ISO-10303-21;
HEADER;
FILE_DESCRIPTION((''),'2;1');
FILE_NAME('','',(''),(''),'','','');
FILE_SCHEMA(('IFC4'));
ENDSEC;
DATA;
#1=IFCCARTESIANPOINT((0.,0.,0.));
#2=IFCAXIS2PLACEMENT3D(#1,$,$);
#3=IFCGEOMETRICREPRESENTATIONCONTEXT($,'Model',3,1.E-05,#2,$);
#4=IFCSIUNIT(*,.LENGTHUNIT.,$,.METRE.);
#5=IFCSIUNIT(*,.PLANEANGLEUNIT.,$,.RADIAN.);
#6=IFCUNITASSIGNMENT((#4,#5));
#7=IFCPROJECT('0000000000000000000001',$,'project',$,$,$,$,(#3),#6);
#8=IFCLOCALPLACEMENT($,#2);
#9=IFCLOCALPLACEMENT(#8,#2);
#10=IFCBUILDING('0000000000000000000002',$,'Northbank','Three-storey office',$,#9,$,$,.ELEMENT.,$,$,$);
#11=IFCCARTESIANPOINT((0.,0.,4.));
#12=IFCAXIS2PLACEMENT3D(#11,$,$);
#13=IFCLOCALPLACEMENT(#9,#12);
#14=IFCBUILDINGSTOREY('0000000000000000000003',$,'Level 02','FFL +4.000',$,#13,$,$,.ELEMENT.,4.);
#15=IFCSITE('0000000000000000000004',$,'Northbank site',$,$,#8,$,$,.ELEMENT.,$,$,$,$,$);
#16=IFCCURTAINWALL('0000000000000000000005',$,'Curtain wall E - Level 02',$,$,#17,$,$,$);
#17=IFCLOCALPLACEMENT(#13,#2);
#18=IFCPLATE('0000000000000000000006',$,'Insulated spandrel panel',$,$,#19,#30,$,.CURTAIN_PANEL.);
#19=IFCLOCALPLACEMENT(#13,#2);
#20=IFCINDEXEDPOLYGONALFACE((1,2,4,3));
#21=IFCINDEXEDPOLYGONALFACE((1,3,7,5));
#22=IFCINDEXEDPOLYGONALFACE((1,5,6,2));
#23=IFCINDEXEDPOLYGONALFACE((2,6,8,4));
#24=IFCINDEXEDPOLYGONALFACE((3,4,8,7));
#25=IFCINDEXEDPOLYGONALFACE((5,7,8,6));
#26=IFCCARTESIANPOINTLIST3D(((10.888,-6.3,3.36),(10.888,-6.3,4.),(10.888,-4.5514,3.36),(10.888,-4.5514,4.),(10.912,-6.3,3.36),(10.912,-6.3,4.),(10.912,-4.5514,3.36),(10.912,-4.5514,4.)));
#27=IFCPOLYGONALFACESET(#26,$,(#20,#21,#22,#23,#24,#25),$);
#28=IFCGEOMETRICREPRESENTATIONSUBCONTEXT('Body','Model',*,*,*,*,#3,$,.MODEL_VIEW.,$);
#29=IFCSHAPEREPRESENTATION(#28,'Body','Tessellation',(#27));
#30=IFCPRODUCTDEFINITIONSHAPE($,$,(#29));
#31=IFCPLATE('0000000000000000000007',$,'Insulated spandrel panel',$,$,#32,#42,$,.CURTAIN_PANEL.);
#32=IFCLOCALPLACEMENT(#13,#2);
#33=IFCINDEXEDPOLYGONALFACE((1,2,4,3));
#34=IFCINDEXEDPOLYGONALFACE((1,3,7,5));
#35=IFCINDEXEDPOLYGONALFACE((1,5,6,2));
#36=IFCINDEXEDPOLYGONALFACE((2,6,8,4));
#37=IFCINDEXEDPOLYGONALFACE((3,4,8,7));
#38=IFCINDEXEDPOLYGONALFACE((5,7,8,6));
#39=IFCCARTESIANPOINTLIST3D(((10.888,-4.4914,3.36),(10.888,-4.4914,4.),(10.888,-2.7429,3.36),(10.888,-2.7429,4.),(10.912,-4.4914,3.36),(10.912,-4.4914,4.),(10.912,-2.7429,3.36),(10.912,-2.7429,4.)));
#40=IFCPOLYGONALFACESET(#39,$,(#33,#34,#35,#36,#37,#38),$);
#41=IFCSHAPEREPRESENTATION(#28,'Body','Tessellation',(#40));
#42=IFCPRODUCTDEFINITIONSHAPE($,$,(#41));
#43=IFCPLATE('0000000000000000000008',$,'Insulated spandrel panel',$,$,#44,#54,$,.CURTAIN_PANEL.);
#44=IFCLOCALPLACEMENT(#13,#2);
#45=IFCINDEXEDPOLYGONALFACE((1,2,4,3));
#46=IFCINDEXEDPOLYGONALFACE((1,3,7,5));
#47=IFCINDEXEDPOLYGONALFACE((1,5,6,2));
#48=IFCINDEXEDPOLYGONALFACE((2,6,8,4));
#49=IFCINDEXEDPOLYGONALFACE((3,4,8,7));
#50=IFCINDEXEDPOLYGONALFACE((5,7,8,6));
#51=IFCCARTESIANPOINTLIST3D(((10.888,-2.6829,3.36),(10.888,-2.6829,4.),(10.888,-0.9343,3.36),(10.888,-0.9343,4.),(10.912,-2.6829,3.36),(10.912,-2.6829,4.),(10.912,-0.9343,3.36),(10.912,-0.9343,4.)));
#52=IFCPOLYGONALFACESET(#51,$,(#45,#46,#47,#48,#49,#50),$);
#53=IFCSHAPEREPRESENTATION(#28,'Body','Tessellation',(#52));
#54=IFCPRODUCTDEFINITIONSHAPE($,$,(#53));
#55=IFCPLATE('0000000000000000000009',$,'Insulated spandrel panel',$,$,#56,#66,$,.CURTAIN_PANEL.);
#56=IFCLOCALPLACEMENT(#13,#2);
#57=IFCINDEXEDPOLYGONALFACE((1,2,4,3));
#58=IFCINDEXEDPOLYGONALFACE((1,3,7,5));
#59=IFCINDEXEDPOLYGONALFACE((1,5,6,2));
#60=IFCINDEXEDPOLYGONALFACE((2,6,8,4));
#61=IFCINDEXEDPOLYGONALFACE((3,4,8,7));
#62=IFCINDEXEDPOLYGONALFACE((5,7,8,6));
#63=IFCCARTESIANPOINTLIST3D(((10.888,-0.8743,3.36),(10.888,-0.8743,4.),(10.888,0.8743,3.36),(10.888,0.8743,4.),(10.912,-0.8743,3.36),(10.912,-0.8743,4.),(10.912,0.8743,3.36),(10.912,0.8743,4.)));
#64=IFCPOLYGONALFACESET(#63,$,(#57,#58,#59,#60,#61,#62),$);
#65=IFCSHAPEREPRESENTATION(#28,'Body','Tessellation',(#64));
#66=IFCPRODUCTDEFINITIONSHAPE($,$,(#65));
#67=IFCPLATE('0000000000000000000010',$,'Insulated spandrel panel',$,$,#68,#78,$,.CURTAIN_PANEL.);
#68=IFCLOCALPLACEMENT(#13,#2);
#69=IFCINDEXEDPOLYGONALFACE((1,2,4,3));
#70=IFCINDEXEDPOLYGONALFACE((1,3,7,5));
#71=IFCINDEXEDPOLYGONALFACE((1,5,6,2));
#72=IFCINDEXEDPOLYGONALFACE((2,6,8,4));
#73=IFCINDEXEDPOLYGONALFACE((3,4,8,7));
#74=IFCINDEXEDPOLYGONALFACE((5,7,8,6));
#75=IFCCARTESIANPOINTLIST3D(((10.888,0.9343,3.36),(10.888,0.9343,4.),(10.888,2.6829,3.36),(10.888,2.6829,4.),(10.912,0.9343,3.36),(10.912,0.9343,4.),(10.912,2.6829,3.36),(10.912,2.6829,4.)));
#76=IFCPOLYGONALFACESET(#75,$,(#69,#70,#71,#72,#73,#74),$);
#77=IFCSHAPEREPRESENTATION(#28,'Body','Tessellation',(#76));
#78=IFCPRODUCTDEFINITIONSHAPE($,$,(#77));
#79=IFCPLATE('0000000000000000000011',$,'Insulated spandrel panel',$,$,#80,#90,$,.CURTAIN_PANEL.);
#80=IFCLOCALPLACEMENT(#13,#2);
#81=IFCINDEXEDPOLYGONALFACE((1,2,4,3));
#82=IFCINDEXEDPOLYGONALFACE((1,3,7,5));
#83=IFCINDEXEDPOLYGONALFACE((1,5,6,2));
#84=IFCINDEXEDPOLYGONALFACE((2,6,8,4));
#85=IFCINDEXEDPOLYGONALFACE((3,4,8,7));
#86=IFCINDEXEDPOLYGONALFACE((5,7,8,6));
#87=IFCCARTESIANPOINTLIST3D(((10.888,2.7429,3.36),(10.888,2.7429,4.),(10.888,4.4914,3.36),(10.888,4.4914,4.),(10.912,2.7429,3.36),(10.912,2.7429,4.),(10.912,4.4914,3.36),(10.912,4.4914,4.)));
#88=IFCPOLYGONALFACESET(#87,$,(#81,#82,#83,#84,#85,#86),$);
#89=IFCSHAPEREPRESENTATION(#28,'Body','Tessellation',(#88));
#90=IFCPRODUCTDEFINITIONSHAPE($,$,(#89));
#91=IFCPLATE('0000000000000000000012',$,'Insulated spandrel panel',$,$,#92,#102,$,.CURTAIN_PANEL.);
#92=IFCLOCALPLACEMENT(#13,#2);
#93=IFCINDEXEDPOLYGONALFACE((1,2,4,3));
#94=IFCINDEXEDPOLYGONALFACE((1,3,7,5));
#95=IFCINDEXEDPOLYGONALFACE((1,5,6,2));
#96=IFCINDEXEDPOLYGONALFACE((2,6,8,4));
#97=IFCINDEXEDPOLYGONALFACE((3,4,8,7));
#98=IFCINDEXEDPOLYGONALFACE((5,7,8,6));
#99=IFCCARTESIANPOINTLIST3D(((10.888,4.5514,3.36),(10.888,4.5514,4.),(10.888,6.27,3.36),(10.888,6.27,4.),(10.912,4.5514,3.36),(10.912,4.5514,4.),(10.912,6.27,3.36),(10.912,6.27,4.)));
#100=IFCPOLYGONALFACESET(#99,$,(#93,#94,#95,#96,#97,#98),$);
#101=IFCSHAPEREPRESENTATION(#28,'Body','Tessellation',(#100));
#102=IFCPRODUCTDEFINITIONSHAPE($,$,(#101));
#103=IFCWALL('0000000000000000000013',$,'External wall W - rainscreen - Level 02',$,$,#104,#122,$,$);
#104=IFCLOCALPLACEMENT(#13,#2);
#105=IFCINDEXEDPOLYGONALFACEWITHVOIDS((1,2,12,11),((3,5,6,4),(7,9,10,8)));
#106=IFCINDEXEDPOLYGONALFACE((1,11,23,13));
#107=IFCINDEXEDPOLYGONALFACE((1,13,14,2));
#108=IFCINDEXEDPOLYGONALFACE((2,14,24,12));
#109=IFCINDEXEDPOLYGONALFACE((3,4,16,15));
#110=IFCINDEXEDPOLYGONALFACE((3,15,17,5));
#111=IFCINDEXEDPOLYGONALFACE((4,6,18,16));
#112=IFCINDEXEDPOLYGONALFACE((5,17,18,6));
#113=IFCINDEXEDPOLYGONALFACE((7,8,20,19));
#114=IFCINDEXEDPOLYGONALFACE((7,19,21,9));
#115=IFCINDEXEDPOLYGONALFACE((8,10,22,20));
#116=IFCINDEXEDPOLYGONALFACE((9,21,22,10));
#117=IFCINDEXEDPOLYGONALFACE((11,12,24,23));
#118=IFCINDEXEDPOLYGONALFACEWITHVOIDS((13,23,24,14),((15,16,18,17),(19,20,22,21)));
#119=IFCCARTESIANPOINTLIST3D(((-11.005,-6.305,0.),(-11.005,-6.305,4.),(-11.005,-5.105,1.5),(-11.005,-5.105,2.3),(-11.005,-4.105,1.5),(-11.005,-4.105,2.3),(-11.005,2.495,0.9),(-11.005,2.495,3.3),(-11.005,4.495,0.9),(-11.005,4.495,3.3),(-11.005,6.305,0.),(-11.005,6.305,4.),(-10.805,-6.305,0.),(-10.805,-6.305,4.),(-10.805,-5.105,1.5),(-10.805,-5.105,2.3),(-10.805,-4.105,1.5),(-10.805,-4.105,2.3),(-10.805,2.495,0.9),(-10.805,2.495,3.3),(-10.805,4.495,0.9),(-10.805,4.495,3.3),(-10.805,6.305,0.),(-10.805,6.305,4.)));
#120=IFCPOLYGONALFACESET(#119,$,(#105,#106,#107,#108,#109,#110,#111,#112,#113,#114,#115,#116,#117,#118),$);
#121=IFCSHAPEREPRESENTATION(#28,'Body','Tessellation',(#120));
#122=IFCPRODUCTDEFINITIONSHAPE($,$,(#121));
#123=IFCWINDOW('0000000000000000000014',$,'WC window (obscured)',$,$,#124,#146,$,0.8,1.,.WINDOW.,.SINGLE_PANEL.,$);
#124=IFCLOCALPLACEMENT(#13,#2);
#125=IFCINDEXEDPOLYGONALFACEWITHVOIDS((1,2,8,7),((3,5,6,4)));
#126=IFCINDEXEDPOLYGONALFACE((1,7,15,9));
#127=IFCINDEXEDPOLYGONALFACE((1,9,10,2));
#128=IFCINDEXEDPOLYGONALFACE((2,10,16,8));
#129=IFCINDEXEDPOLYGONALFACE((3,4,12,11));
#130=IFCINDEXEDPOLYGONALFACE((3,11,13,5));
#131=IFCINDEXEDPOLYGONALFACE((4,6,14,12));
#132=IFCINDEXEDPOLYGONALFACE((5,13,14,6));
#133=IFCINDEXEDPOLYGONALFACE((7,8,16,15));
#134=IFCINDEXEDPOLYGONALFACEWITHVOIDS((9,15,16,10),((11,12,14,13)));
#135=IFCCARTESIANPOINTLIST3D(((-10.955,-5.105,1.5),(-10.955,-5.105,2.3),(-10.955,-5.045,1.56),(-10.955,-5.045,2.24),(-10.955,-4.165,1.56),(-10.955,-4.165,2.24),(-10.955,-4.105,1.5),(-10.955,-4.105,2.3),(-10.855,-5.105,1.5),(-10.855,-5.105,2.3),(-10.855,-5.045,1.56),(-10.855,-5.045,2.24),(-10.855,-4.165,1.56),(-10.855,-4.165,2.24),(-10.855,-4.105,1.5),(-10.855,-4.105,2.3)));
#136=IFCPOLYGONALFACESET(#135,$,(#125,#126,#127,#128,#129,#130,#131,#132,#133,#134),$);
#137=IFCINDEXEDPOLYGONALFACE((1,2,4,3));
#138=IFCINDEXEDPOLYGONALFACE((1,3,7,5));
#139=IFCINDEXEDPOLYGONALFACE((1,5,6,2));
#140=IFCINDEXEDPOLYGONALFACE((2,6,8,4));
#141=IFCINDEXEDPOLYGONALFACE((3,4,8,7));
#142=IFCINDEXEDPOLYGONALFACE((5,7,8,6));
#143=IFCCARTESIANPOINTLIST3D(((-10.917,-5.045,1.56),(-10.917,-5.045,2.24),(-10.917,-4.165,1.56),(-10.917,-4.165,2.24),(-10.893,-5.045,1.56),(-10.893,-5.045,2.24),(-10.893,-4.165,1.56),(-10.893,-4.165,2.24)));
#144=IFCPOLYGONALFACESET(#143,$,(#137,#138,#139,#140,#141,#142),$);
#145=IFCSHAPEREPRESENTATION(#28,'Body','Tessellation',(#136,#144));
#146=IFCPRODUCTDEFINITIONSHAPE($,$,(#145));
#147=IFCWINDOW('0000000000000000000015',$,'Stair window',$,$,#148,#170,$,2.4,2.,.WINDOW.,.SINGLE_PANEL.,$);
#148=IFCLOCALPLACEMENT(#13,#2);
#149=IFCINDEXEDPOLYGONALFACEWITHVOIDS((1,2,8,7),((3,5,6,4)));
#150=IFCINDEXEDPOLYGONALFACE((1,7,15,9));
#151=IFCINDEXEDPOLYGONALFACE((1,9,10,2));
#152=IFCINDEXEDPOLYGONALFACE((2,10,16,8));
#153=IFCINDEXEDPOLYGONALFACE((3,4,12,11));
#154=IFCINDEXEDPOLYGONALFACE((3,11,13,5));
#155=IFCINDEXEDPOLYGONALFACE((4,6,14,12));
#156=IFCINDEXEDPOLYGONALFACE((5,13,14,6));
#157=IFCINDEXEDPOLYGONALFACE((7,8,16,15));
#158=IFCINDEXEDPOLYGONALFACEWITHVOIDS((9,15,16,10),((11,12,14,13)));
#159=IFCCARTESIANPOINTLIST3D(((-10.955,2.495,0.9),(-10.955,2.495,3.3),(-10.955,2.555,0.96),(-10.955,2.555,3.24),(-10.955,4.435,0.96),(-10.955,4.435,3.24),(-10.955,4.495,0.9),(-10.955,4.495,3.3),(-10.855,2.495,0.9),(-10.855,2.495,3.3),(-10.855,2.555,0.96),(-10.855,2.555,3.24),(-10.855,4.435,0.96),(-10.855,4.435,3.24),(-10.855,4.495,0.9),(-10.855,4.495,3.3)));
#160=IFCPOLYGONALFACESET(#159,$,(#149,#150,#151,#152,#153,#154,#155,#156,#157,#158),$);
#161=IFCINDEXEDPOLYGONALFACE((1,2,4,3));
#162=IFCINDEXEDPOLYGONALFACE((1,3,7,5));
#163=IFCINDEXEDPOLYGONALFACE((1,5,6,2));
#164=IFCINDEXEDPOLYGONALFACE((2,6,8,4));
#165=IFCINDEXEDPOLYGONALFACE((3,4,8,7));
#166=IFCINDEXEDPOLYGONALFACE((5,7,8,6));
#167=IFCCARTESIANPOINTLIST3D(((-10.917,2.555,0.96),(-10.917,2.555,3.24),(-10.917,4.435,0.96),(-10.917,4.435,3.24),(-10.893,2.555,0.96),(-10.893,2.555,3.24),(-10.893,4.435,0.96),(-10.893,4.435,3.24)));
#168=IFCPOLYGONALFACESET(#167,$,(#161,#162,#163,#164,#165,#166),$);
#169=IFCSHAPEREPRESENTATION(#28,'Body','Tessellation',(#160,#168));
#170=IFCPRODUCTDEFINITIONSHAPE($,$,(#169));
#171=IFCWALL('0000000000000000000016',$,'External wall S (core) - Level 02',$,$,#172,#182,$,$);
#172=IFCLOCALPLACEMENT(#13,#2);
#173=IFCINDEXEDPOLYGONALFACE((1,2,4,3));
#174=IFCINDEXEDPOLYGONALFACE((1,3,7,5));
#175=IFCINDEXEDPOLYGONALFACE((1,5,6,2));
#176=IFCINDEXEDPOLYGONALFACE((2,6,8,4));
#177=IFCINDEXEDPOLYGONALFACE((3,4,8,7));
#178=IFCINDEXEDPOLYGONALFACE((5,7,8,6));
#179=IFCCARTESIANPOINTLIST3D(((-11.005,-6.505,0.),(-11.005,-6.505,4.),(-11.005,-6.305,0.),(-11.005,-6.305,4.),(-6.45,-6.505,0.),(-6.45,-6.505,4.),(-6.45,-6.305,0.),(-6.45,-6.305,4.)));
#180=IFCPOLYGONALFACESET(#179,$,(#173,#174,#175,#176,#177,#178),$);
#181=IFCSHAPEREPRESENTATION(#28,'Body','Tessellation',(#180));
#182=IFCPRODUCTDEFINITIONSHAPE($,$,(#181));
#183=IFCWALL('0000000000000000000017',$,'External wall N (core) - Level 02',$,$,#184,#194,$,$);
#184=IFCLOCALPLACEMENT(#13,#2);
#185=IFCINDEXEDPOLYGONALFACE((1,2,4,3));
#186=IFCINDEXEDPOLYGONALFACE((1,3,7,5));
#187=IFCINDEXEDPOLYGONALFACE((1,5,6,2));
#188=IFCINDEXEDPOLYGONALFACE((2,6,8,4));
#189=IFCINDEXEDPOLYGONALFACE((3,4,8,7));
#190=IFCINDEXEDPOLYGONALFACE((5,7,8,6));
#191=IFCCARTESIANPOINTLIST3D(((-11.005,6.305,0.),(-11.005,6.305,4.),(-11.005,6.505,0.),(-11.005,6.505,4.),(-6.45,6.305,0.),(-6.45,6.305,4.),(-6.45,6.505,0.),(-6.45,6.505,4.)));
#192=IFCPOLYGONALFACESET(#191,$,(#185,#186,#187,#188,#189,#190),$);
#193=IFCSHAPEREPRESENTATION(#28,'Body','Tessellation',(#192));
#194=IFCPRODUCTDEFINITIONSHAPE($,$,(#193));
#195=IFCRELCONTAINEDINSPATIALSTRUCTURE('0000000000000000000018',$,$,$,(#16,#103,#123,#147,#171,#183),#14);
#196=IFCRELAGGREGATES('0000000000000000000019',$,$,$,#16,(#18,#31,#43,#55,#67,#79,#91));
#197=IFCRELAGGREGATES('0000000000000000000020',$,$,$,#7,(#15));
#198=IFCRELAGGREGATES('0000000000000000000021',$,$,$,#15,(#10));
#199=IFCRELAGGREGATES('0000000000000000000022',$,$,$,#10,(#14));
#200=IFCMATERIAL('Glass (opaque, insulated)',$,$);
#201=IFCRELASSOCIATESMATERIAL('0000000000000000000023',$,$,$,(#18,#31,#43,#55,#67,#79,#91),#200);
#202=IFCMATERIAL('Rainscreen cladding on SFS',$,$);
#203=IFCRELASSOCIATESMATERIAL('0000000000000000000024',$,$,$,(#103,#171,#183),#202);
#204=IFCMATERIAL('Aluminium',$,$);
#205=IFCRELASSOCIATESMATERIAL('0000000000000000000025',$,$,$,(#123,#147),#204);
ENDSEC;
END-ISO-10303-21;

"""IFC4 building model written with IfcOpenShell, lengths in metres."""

from ifc_helpers import new_model, si_unit, frame, origin, place, context, subcontext, project, spatial, polyline, rectangle, outline, extrude, material, element, fill, aggregate, save


model = new_model("IFC4")

# Units and contexts
model_context = context("Model", 3, precision=1e-05, world=origin())
body_context = subcontext(model_context, "Body", "Model", "MODEL_VIEW")
ifc_project = project(units=[si_unit("LENGTHUNIT", "METRE"), si_unit("PLANEANGLEUNIT", "RADIAN")], contexts=[model_context])

# Site, building, storey
site_placement = place(None, origin())
site = spatial("IfcSite", under=ifc_project, at=site_placement, Name="Northbank site", CompositionType="ELEMENT")
building_placement = place(site_placement, origin())
building = spatial("IfcBuilding", under=site, at=building_placement, Name="Northbank", Description="Three-storey office", CompositionType="ELEMENT")
storey_placement = place(building_placement, frame((0.0, 0.0, 4.0)))
storey = spatial("IfcBuildingStorey", under=building, at=storey_placement, Name="Level 02", Description="FFL +4.000", CompositionType="ELEMENT", Elevation=4.0)

# Curtain wall, plates
curtain_wall_placement = place(storey_placement, frame((0.0, 0.0, -4.0)))
curtain_wall = element("IfcCurtainWall", 1, at=curtain_wall_placement, inside=storey, Name="Curtain wall E - Level 02")
ifc_material_1 = material(Name="Aluminium")
ifc_material_2 = material(Name="Glass (opaque, insulated)")
plate_1_placement = place(storey_placement, frame((0.0, 0.0, -4.0)))
plate_1 = element("IfcPlate", 2, at=plate_1_placement, material=ifc_material_2, Name="Insulated spandrel panel", PredefinedType="CURTAIN_PANEL", context=body_context, shape_type="SweptSolid", body=[
    extrude(rectangle(XDim=0.024, YDim=1.7486), frame((10.9, -5.4257, 7.36)), (0.0, 0.0, 1.0), 0.64),
])
plate_2_placement = place(storey_placement, frame((0.0, 0.0, -4.0)))
plate_2 = element("IfcPlate", 3, at=plate_2_placement, material=ifc_material_2, Name="Insulated spandrel panel", PredefinedType="CURTAIN_PANEL", context=body_context, shape_type="SweptSolid", body=[
    extrude(rectangle(XDim=0.024, YDim=1.7486), frame((10.9, -3.6171, 7.36)), (0.0, 0.0, 1.0), 0.64),
])
plate_3_placement = place(storey_placement, frame((0.0, 0.0, -4.0)))
plate_3 = element("IfcPlate", 4, at=plate_3_placement, material=ifc_material_2, Name="Insulated spandrel panel", PredefinedType="CURTAIN_PANEL", context=body_context, shape_type="SweptSolid", body=[
    extrude(rectangle(XDim=0.024, YDim=1.7486), frame((10.9, -1.8086, 7.36)), (0.0, 0.0, 1.0), 0.64),
])
plate_4_placement = place(storey_placement, frame((0.0, 0.0, -4.0)))
plate_4 = element("IfcPlate", 5, at=plate_4_placement, material=ifc_material_2, Name="Insulated spandrel panel", PredefinedType="CURTAIN_PANEL", context=body_context, shape_type="SweptSolid", body=[
    extrude(rectangle(XDim=0.024, YDim=1.7486), frame((10.9, 0.0, 7.36)), (0.0, 0.0, 1.0), 0.64),
])
plate_5_placement = place(storey_placement, frame((0.0, 0.0, -4.0)))
plate_5 = element("IfcPlate", 6, at=plate_5_placement, material=ifc_material_2, Name="Insulated spandrel panel", PredefinedType="CURTAIN_PANEL", context=body_context, shape_type="SweptSolid", body=[
    extrude(rectangle(XDim=0.024, YDim=1.7486), frame((10.9, 1.8086, 7.36)), (0.0, 0.0, 1.0), 0.64),
])
plate_6_placement = place(storey_placement, frame((0.0, 0.0, -4.0)))
plate_6 = element("IfcPlate", 7, at=plate_6_placement, material=ifc_material_2, Name="Insulated spandrel panel", PredefinedType="CURTAIN_PANEL", context=body_context, shape_type="SweptSolid", body=[
    extrude(rectangle(XDim=0.024, YDim=1.7486), frame((10.9, 3.6171, 7.36)), (0.0, 0.0, 1.0), 0.64),
])
plate_7_placement = place(storey_placement, frame((0.0, 0.0, -4.0)))
plate_7 = element("IfcPlate", 8, at=plate_7_placement, material=ifc_material_2, Name="Insulated spandrel panel", PredefinedType="CURTAIN_PANEL", context=body_context, shape_type="SweptSolid", body=[
    extrude(rectangle(XDim=0.024, YDim=1.7186), frame((10.9, 5.4107, 7.36)), (0.0, 0.0, 1.0), 0.64),
])
aggregate(curtain_wall, [plate_1, plate_2, plate_3, plate_4, plate_5, plate_6, plate_7])

# Wall, openings, windows
ifc_material_3 = material(Name="Rainscreen cladding on SFS")
wall_1_placement = place(storey_placement, frame((0.0, 0.0, -4.0)))
wall_1 = element("IfcWall", 9, at=wall_1_placement, inside=storey, material=ifc_material_3, Name="External wall W - rainscreen - Level 02", context=body_context, shape_type="SweptSolid", body=[
    extrude(outline(polyline([(0.0, 0.0), (12.61, 0.0), (12.61, 4.0), (0.0, 4.0), (0.0, 0.0)]), holes=[polyline([(1.2, 1.5), (1.2, 2.3), (2.2, 2.3), (2.2, 1.5), (1.2, 1.5)]), polyline([(8.8, 0.9), (8.8, 3.3), (10.8, 3.3), (10.8, 0.9), (8.8, 0.9)])]), frame((-11.005, -6.305, 4.0), z_axis=(1.0, 0.0, 0.0), x_axis=(0.0, 1.0, 0.0)), (0.0, 0.0, 1.0), 0.2),
])
opening_1_placement = place(storey_placement, frame((0.0, 0.0, -4.0)))
opening_1 = element("IfcOpeningElement", 10, at=opening_1_placement, cuts=wall_1, PredefinedType="OPENING", context=body_context, shape_type="SweptSolid", body=[
    extrude(outline(polyline([(0.0, 0.0), (1.0, 0.0), (1.0, 0.8), (0.0, 0.8), (0.0, 0.0)])), frame((-11.055, -5.105, 5.5), z_axis=(1.0, 0.0, 0.0), x_axis=(0.0, 1.0, 0.0)), (0.0, 0.0, 1.0), 0.3),
])
opening_2_placement = place(storey_placement, frame((0.0, 0.0, -4.0)))
opening_2 = element("IfcOpeningElement", 11, at=opening_2_placement, cuts=wall_1, PredefinedType="OPENING", context=body_context, shape_type="SweptSolid", body=[
    extrude(outline(polyline([(0.0, 0.0), (2.0, 0.0), (2.0, 2.4), (0.0, 2.4), (0.0, 0.0)])), frame((-11.055, 2.495, 4.9), z_axis=(1.0, 0.0, 0.0), x_axis=(0.0, 1.0, 0.0)), (0.0, 0.0, 1.0), 0.3),
])
window_1_placement = place(storey_placement, frame((0.0, 0.0, -4.0)))
window_1 = element("IfcWindow", 12, at=window_1_placement, inside=storey, material=ifc_material_1, Name="WC window (obscured)", OverallHeight=0.8, OverallWidth=1.0, PartitioningType="SINGLE_PANEL", PredefinedType="WINDOW", context=body_context, shape_type="SweptSolid", body=[
    extrude(outline(polyline([(0.0, 0.0), (1.0, 0.0), (1.0, 0.8), (0.0, 0.8), (0.0, 0.0)]), holes=[polyline([(0.06, 0.06), (0.06, 0.74), (0.94, 0.74), (0.94, 0.06), (0.06, 0.06)])]), frame((-10.955, -5.105, 5.5), z_axis=(1.0, 0.0, 0.0), x_axis=(0.0, 1.0, 0.0)), (0.0, 0.0, 1.0), 0.1),
    extrude(outline(polyline([(0.0, 0.0), (0.88, 0.0), (0.88, 0.68), (0.0, 0.68), (0.0, 0.0)])), frame((-10.917, -5.045, 5.56), z_axis=(1.0, 0.0, 0.0), x_axis=(0.0, 1.0, 0.0)), (0.0, 0.0, 1.0), 0.024),
])
fill(opening_1, window_1)
window_2_placement = place(storey_placement, frame((0.0, 0.0, -4.0)))
window_2 = element("IfcWindow", 13, at=window_2_placement, inside=storey, material=ifc_material_1, Name="Stair window", OverallHeight=2.4, OverallWidth=2.0, PartitioningType="SINGLE_PANEL", PredefinedType="WINDOW", context=body_context, shape_type="SweptSolid", body=[
    extrude(outline(polyline([(0.0, 0.0), (2.0, 0.0), (2.0, 2.4), (0.0, 2.4), (0.0, 0.0)]), holes=[polyline([(0.06, 0.06), (0.06, 2.34), (1.94, 2.34), (1.94, 0.06), (0.06, 0.06)])]), frame((-10.955, 2.495, 4.9), z_axis=(1.0, 0.0, 0.0), x_axis=(0.0, 1.0, 0.0)), (0.0, 0.0, 1.0), 0.1),
    extrude(outline(polyline([(0.0, 0.0), (1.88, 0.0), (1.88, 2.28), (0.0, 2.28), (0.0, 0.0)])), frame((-10.917, 2.555, 4.96), z_axis=(1.0, 0.0, 0.0), x_axis=(0.0, 1.0, 0.0)), (0.0, 0.0, 1.0), 0.024),
])
fill(opening_2, window_2)

# Walls
wall_2_placement = place(storey_placement, frame((0.0, 0.0, -4.0)))
element("IfcWall", 14, at=wall_2_placement, inside=storey, material=ifc_material_3, Name="External wall S (core) - Level 02", context=body_context, shape_type="SweptSolid", body=[
    extrude(outline(polyline([(0.0, 0.0), (4.555, 0.0), (4.555, 4.0), (0.0, 4.0), (0.0, 0.0)])), frame((-11.005, -6.305, 4.0), z_axis=(0.0, -1.0, 0.0), x_axis=(1.0, 0.0, 0.0)), (0.0, 0.0, 1.0), 0.2),
])
wall_3_placement = place(storey_placement, frame((0.0, 0.0, -4.0)))
element("IfcWall", 15, at=wall_3_placement, inside=storey, material=ifc_material_3, Name="External wall N (core) - Level 02", context=body_context, shape_type="SweptSolid", body=[
    extrude(outline(polyline([(0.0, 0.0), (4.555, 0.0), (4.555, 4.0), (0.0, 4.0), (0.0, 0.0)])), frame((-11.005, 6.505, 4.0), z_axis=(0.0, -1.0, 0.0), x_axis=(1.0, 0.0, 0.0)), (0.0, 0.0, 1.0), 0.2),
])

save(model, "model.ifc")
